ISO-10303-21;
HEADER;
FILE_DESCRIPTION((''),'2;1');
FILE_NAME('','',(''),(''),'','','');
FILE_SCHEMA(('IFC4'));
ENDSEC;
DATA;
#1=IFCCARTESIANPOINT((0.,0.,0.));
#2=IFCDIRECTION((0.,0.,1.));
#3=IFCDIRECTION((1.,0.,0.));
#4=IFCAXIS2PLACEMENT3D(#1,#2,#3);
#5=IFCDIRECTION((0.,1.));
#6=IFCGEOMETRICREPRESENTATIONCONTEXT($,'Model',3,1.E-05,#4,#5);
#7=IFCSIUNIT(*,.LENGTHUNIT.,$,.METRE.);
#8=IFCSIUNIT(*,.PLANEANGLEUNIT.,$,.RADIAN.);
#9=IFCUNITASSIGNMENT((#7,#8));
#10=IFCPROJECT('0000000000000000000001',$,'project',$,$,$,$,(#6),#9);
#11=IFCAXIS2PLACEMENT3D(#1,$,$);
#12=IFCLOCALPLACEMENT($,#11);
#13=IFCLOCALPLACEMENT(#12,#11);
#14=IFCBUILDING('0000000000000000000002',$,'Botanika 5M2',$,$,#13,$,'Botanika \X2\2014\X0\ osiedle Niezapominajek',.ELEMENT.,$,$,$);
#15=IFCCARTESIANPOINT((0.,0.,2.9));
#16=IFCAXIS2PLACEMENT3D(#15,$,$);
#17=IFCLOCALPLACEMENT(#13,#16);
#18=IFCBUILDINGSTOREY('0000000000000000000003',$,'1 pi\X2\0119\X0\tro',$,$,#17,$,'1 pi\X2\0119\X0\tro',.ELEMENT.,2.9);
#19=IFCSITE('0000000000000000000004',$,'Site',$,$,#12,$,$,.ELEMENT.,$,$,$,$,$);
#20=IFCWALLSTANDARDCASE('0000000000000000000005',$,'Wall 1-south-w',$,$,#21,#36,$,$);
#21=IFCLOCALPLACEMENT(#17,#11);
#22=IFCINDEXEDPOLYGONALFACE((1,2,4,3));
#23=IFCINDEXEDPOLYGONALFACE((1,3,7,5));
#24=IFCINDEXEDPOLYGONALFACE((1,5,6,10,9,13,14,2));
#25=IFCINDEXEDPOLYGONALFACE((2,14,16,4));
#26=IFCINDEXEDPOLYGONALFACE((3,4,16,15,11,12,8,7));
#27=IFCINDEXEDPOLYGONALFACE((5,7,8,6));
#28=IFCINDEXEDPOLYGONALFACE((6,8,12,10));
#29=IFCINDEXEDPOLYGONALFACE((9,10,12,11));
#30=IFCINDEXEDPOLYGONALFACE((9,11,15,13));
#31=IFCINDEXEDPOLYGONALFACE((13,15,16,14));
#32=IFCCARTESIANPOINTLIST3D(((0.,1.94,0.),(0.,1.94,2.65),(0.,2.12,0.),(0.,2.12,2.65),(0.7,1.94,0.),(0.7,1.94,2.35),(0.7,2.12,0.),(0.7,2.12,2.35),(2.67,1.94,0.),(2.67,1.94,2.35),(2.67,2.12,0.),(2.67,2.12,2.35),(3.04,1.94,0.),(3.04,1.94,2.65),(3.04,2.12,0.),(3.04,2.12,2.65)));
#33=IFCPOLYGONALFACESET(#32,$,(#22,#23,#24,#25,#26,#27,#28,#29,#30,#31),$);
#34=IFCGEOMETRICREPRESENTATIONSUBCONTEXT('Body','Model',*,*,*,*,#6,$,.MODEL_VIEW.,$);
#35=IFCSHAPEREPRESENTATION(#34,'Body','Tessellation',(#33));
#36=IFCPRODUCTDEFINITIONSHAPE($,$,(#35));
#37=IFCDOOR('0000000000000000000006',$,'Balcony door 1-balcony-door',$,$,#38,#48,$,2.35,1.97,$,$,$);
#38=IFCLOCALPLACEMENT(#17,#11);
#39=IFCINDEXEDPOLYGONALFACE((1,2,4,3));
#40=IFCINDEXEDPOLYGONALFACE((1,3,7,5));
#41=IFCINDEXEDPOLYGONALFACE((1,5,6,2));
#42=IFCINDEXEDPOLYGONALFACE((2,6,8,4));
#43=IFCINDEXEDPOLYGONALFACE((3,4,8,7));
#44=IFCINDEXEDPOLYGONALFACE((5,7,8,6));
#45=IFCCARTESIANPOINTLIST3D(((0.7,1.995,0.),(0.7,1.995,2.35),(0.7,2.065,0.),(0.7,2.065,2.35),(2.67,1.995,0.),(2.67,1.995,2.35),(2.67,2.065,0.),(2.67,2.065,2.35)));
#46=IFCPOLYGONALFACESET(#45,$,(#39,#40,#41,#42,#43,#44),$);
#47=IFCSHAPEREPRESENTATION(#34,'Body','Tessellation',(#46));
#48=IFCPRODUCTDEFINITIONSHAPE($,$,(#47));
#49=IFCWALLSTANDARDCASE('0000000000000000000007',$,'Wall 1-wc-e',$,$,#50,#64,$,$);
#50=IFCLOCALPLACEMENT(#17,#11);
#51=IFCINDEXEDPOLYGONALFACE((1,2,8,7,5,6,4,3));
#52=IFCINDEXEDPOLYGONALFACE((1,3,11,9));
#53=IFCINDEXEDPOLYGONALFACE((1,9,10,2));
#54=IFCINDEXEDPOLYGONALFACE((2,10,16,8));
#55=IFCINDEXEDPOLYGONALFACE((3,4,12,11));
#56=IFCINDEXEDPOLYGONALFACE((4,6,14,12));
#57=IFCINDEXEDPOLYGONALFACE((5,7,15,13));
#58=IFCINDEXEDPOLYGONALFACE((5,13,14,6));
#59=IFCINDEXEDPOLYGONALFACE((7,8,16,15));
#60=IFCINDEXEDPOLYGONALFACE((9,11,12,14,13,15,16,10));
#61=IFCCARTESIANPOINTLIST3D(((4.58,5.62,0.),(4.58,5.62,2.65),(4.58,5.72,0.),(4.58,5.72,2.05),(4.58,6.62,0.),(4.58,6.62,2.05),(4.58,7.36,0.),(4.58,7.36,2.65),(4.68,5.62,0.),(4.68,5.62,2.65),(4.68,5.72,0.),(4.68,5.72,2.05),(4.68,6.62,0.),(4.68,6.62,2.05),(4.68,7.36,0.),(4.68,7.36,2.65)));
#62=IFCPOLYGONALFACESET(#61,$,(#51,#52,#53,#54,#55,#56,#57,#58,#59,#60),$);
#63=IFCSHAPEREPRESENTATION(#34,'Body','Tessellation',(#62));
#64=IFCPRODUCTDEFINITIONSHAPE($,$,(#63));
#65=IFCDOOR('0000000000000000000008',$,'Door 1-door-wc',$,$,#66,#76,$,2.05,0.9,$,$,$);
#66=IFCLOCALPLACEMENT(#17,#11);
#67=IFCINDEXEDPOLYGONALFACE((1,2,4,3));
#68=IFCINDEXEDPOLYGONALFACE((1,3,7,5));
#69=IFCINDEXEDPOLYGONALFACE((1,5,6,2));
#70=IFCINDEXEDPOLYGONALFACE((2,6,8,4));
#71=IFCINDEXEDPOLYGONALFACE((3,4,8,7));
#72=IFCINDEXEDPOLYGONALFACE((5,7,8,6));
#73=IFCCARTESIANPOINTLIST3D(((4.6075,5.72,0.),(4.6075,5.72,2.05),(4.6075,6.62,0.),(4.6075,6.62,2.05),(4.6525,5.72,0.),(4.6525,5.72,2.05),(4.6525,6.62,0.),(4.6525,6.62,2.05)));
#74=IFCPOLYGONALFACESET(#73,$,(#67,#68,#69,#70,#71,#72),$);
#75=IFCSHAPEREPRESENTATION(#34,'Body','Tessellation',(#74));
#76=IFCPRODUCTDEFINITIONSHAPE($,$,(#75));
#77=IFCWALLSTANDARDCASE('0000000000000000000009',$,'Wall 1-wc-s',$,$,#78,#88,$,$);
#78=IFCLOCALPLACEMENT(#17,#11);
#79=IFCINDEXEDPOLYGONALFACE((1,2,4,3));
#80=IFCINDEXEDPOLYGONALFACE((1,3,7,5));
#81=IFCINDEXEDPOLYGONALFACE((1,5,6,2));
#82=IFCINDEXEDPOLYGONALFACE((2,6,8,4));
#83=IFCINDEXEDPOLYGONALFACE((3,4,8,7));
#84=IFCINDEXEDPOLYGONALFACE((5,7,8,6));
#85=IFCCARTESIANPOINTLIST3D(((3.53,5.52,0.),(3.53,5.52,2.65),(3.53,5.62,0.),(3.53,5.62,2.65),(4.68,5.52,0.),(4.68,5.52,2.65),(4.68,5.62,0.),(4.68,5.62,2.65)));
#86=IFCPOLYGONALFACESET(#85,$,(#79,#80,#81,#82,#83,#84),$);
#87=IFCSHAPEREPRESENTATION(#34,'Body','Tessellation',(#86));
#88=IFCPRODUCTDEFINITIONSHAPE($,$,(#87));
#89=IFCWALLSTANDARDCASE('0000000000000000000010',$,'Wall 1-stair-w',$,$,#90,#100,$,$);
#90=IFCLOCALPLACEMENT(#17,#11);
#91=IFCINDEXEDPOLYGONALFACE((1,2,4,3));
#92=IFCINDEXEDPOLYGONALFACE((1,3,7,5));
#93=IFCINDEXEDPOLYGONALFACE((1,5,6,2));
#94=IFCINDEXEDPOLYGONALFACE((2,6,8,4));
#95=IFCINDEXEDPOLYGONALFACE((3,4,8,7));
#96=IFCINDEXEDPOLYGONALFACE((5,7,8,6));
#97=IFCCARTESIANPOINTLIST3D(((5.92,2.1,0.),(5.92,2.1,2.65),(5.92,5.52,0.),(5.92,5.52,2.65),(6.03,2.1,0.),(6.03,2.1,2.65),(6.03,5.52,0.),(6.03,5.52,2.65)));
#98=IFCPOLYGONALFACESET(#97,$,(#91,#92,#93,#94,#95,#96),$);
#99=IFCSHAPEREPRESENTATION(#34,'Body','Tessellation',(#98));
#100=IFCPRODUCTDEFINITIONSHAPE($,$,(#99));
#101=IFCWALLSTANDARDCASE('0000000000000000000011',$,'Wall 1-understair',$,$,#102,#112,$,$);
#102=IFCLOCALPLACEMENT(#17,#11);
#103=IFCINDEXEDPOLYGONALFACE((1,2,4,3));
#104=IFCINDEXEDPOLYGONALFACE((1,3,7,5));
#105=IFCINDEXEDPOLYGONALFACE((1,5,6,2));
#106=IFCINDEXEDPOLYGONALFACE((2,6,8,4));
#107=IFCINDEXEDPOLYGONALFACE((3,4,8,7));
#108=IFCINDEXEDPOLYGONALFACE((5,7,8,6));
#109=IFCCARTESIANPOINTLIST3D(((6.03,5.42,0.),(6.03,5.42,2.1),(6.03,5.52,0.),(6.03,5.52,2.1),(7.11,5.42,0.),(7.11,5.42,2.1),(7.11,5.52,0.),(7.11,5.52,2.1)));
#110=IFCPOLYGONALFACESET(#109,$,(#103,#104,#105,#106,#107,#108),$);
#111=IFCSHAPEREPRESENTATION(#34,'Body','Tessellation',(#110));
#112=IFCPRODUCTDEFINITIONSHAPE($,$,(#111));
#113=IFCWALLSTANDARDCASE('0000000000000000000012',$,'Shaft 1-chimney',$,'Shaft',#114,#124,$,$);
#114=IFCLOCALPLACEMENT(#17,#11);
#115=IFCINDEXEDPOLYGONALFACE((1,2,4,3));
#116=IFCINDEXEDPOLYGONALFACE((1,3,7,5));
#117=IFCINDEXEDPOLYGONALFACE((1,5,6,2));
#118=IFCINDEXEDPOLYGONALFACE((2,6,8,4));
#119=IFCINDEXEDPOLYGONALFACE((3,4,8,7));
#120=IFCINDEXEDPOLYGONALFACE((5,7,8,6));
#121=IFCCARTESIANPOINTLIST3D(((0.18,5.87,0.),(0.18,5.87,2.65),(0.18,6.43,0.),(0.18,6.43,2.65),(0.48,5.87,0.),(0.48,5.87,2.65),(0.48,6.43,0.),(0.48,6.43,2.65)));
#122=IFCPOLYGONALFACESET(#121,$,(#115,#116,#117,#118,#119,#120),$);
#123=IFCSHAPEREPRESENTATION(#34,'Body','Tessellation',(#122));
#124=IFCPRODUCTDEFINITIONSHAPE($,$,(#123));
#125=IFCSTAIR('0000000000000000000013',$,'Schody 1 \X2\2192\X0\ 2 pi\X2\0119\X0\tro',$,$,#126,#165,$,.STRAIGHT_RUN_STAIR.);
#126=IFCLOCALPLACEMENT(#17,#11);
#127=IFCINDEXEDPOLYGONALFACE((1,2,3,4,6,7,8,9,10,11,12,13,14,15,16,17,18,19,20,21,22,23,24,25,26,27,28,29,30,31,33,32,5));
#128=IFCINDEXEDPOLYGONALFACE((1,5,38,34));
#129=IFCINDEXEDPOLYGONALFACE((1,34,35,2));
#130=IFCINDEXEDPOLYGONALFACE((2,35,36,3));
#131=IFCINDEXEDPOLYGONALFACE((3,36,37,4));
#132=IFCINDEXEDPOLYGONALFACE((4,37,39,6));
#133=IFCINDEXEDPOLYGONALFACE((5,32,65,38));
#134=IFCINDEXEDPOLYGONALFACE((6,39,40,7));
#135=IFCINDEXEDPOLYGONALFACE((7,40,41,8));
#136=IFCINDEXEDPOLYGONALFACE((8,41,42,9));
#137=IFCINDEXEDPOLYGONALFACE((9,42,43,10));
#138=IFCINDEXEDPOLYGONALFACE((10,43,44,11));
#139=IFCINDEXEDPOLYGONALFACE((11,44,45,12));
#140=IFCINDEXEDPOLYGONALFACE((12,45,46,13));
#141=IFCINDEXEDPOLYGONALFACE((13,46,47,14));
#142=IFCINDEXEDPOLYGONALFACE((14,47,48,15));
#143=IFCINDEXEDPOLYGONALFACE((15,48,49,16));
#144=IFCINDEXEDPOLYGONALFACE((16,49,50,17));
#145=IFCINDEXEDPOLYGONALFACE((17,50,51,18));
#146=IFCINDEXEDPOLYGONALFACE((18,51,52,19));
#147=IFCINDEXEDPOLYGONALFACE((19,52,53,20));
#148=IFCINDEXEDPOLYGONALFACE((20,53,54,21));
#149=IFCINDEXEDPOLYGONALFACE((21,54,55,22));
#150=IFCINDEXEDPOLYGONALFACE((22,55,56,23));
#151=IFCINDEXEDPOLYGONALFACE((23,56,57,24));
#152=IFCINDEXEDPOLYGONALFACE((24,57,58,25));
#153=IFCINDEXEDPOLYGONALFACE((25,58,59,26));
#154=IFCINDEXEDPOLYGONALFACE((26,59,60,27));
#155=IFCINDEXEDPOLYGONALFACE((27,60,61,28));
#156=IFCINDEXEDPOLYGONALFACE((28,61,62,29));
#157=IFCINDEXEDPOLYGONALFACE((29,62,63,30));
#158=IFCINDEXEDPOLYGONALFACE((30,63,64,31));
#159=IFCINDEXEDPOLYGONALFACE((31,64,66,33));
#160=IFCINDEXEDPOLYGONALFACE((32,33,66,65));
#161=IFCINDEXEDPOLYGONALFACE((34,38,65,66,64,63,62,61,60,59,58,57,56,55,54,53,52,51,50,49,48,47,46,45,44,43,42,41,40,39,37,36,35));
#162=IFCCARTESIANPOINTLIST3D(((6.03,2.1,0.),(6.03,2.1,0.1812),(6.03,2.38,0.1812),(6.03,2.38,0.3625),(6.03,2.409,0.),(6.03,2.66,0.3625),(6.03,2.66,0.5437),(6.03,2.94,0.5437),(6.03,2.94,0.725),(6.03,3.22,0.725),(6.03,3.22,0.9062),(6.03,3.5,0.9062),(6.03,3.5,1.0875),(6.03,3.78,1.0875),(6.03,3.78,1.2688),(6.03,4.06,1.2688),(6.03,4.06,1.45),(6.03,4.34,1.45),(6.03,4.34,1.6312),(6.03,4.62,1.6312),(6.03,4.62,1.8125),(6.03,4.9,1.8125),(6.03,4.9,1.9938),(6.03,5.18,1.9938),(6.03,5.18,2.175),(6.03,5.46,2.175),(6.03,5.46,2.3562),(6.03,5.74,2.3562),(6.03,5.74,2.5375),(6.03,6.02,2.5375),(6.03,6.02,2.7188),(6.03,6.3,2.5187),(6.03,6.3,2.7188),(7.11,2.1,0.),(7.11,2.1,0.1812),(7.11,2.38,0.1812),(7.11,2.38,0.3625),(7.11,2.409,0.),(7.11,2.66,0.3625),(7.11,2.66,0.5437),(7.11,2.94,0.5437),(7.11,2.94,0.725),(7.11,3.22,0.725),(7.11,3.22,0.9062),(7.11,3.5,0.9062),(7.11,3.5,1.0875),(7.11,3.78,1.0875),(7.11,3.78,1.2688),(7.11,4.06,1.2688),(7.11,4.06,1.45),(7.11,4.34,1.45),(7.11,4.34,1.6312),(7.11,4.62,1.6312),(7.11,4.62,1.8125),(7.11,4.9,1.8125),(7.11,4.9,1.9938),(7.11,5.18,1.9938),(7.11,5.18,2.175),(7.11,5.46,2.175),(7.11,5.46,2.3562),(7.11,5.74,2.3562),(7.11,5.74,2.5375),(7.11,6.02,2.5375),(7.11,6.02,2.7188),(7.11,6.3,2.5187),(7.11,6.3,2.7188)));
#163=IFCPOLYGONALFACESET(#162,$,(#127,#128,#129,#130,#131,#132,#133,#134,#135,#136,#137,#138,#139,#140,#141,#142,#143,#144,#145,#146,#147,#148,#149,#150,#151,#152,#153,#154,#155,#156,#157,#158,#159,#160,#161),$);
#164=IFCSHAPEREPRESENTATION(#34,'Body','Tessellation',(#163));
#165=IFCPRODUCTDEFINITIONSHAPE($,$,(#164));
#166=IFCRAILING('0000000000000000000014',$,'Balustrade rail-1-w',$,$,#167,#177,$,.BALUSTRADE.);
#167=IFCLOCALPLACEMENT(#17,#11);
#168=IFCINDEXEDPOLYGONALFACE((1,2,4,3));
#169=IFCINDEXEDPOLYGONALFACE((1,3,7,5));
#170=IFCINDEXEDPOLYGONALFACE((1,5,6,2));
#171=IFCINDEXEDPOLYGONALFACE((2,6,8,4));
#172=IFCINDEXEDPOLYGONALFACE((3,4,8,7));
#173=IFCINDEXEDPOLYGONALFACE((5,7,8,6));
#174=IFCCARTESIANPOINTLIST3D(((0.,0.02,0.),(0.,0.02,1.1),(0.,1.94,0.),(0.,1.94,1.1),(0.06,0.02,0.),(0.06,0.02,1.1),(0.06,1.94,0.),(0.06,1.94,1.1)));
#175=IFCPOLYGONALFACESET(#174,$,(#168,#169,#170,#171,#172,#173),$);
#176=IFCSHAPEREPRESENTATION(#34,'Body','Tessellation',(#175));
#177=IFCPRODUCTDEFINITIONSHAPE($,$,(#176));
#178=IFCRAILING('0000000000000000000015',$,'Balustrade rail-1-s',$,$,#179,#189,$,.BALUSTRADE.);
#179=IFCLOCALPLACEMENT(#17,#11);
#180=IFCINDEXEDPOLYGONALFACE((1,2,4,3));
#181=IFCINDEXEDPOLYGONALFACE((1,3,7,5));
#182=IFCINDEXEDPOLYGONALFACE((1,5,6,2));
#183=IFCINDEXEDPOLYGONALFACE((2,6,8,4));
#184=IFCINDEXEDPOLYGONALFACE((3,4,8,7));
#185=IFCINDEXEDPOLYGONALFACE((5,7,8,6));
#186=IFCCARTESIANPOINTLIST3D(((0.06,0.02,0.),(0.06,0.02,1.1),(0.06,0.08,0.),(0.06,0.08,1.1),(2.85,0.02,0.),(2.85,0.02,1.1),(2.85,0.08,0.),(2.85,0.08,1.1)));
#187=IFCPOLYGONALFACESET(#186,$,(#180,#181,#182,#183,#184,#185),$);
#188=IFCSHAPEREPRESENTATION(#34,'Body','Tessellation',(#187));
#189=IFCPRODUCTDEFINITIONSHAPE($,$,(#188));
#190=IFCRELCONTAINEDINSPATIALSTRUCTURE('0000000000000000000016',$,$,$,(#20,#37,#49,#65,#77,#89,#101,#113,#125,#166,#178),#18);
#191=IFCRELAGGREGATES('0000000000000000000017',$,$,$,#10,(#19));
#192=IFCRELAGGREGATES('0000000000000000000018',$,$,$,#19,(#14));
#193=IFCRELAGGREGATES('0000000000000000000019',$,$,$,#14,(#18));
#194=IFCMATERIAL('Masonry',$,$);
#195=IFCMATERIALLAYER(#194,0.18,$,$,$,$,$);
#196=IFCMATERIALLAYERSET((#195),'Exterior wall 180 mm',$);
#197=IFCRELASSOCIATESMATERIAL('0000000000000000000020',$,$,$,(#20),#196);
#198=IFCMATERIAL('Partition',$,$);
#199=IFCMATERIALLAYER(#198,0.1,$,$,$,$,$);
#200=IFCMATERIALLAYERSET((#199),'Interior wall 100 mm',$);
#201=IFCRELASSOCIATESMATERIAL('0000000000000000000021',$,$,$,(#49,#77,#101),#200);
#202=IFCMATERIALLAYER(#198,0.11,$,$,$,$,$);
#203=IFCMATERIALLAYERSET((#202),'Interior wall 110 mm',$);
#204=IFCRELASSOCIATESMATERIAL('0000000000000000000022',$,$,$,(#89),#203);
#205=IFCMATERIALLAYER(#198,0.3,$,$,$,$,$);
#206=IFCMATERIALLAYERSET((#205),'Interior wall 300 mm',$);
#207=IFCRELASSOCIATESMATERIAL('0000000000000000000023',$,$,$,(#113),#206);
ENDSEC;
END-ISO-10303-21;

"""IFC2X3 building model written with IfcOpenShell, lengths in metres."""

from ifc_helpers import new_model, si_unit, direction, frame, frame_2d, origin, origin_with_axes, place, context, subcontext, project, spatial, polyline, rectangle, outline, extrude, material, layer, layer_set, layer_usage, element, fill, save


model = new_model("IFC2X3")

# Units and contexts
model_context = context("Model", 3, precision=1e-05, world=origin_with_axes(), true_north=direction((0.0, 1.0)))
body_context = subcontext(model_context, "Body", "Model", "MODEL_VIEW")
ifc_project = project(units=[si_unit("LENGTHUNIT", "METRE"), si_unit("PLANEANGLEUNIT", "RADIAN")], contexts=[model_context])

# Site, building, storey
site_placement = place(None, origin())
site = spatial("IfcSite", under=ifc_project, at=site_placement, Name="Site", CompositionType="ELEMENT")
building_placement = place(site_placement, origin())
building = spatial("IfcBuilding", under=site, at=building_placement, Name="Botanika 5M2", LongName="Botanika — osiedle Niezapominajek", CompositionType="ELEMENT")
storey_placement = place(building_placement, frame((0.0, 0.0, 2.9)))
storey = spatial("IfcBuildingStorey", under=building, at=storey_placement, Name="1 piętro", LongName="1 piętro", CompositionType="ELEMENT", Elevation=2.9)

# Shared definitions
ifc_material_1 = material(Name="Masonry")
ifc_layer_1 = layer(ifc_material_1, 0.18)
ifc_layer_set_1 = layer_set([ifc_layer_1], Name="Exterior wall 180 mm")
ifc_layer_usage_1 = layer_usage(ifc_layer_set_1, "AXIS2", "POSITIVE", -0.09)

# Walls, openings, doors
wall_1_placement = place(storey_placement, frame((0.0, 2.03, 0.0)))
wall_1 = element("IfcWallStandardCase", 1, at=wall_1_placement, inside=storey, material=ifc_layer_usage_1, Name="Wall 1-south-w", context=body_context, shape_type="SweptSolid", body=[
    extrude(rectangle(XDim=3.04, YDim=0.18, at=frame_2d((1.52, 0.0))), origin_with_axes(), (0.0, 0.0, 1.0), 2.65),
])
opening_1_placement = place(wall_1_placement, frame((0.7, 0.14, 0.0), z_axis=(0.0, -1.0, 0.0), x_axis=(1.0, 0.0, 0.0)))
opening_1 = element("IfcOpeningElement", 2, at=opening_1_placement, cuts=wall_1, context=body_context, shape_type="SweptSolid", body=[
    extrude(rectangle(XDim=1.97, YDim=2.35, at=frame_2d((0.985, 1.175))), origin_with_axes(), (0.0, 0.0, 1.0), 0.28),
])
door_1_placement = place(wall_1_placement, frame((0.7, 0.0, 0.0)))
door_1 = element("IfcDoor", 3, at=door_1_placement, inside=storey, Name="Balcony door 1-balcony-door", OverallHeight=2.35, OverallWidth=1.97, context=body_context, shape_type="SweptSolid", body=[
    extrude(rectangle(XDim=1.97, YDim=0.07, at=frame_2d((0.985, 0.0))), origin_with_axes(), (0.0, 0.0, 1.0), 2.35),
])
fill(opening_1, door_1)
ifc_material_2 = material(Name="Partition")
ifc_layer_2 = layer(ifc_material_2, 0.1)
ifc_layer_set_2 = layer_set([ifc_layer_2], Name="Interior wall 100 mm")
ifc_layer_usage_2 = layer_usage(ifc_layer_set_2, "AXIS2", "POSITIVE", -0.05)
wall_2_placement = place(storey_placement, frame((4.63, 7.36, 0.0), z_axis=(0.0, 0.0, 1.0), x_axis=(0.0, -1.0, 0.0)))
wall_2 = element("IfcWallStandardCase", 4, at=wall_2_placement, inside=storey, material=ifc_layer_usage_2, Name="Wall 1-wc-e", context=body_context, shape_type="SweptSolid", body=[
    extrude(rectangle(XDim=1.74, YDim=0.1, at=frame_2d((0.87, 0.0))), origin_with_axes(), (0.0, 0.0, 1.0), 2.65),
])
opening_2_placement = place(wall_2_placement, frame((0.74, 0.1, 0.0), z_axis=(0.0, -1.0, 0.0), x_axis=(1.0, 0.0, 0.0)))
opening_2 = element("IfcOpeningElement", 5, at=opening_2_placement, cuts=wall_2, context=body_context, shape_type="SweptSolid", body=[
    extrude(rectangle(XDim=0.9, YDim=2.05, at=frame_2d((0.45, 1.025))), origin_with_axes(), (0.0, 0.0, 1.0), 0.2),
])
door_2_placement = place(wall_2_placement, frame((0.74, 0.0, 0.0)))
door_2 = element("IfcDoor", 6, at=door_2_placement, inside=storey, Name="Door 1-door-wc", OverallHeight=2.05, OverallWidth=0.9, context=body_context, shape_type="SweptSolid", body=[
    extrude(rectangle(XDim=0.9, YDim=0.045, at=frame_2d((0.45, 0.0))), origin_with_axes(), (0.0, 0.0, 1.0), 2.05),
])
fill(opening_2, door_2)

# Walls
wall_3_placement = place(storey_placement, frame((3.53, 5.57, 0.0)))
element("IfcWallStandardCase", 7, at=wall_3_placement, inside=storey, material=ifc_layer_usage_2, Name="Wall 1-wc-s", context=body_context, shape_type="SweptSolid", body=[
    extrude(rectangle(XDim=1.15, YDim=0.1, at=frame_2d((0.575, 0.0))), origin_with_axes(), (0.0, 0.0, 1.0), 2.65),
])
ifc_layer_3 = layer(ifc_material_2, 0.11)
ifc_layer_set_3 = layer_set([ifc_layer_3], Name="Interior wall 110 mm")
ifc_layer_usage_3 = layer_usage(ifc_layer_set_3, "AXIS2", "POSITIVE", -0.055)
wall_4_placement = place(storey_placement, frame((5.975, 5.52, 0.0), z_axis=(0.0, 0.0, 1.0), x_axis=(0.0, -1.0, 0.0)))
element("IfcWallStandardCase", 8, at=wall_4_placement, inside=storey, material=ifc_layer_usage_3, Name="Wall 1-stair-w", context=body_context, shape_type="SweptSolid", body=[
    extrude(rectangle(XDim=3.42, YDim=0.11, at=frame_2d((1.71, 0.0))), origin_with_axes(), (0.0, 0.0, 1.0), 2.65),
])
wall_5_placement = place(storey_placement, frame((6.03, 5.47, 0.0)))
element("IfcWallStandardCase", 9, at=wall_5_placement, inside=storey, material=ifc_layer_usage_2, Name="Wall 1-understair", context=body_context, shape_type="SweptSolid", body=[
    extrude(rectangle(XDim=1.08, YDim=0.1, at=frame_2d((0.54, 0.0))), origin_with_axes(), (0.0, 0.0, 1.0), 2.1),
])
ifc_layer_4 = layer(ifc_material_2, 0.3)
ifc_layer_set_4 = layer_set([ifc_layer_4], Name="Interior wall 300 mm")
ifc_layer_usage_4 = layer_usage(ifc_layer_set_4, "AXIS2", "POSITIVE", -0.15)
wall_6_placement = place(storey_placement, frame((0.33, 6.43, 0.0), z_axis=(0.0, 0.0, 1.0), x_axis=(0.0, -1.0, 0.0)))
element("IfcWallStandardCase", 10, at=wall_6_placement, inside=storey, material=ifc_layer_usage_4, Name="Shaft 1-chimney", ObjectType="Shaft", context=body_context, shape_type="SweptSolid", body=[
    extrude(rectangle(XDim=0.56, YDim=0.3, at=frame_2d((0.28, 0.0))), origin_with_axes(), (0.0, 0.0, 1.0), 2.65),
])

# Stair
stair_placement = place(storey_placement, frame((6.03, 2.1, 0.0), z_axis=(1.0, 0.0, 0.0), x_axis=(0.0, 1.0, 0.0)))
element("IfcStair", 11, at=stair_placement, inside=storey, Name="Schody 1 → 2 piętro", ShapeType="STRAIGHT_RUN_STAIR", context=body_context, shape_type="SweptSolid", body=[
    extrude(outline(polyline([(0.0, 0.0), (0.0, 0.1812), (0.28, 0.1812), (0.28, 0.3625), (0.56, 0.3625), (0.56, 0.5437), (0.84, 0.5437), (0.84, 0.725), (1.12, 0.725), (1.12, 0.9062), (1.4, 0.9062), (1.4, 1.0875), (1.68, 1.0875), (1.68, 1.2688), (1.96, 1.2688), (1.96, 1.45), (2.24, 1.45), (2.24, 1.6313), (2.52, 1.6313), (2.52, 1.8125), (2.8, 1.8125), (2.8, 1.9937), (3.08, 1.9937), (3.08, 2.175), (3.36, 2.175), (3.36, 2.3563), (3.64, 2.3563), (3.64, 2.5375), (3.92, 2.5375), (3.92, 2.7188), (4.2, 2.7188), (4.2, 2.9), (4.2, 2.5187), (0.309, 0.0), (0.0, 0.0)])), origin_with_axes(), (0.0, 0.0, 1.0), 1.08),
])

# Railings
railing_1_placement = place(storey_placement, frame((0.0, 0.02, 0.0)))
element("IfcRailing", 12, at=railing_1_placement, inside=storey, Name="Balustrade rail-1-w", PredefinedType="BALUSTRADE", context=body_context, shape_type="SweptSolid", body=[
    extrude(rectangle(XDim=0.06, YDim=1.92, at=frame_2d((0.03, 0.96))), origin_with_axes(), (0.0, 0.0, 1.0), 1.1),
])
railing_2_placement = place(storey_placement, frame((0.06, 0.02, 0.0)))
element("IfcRailing", 13, at=railing_2_placement, inside=storey, Name="Balustrade rail-1-s", PredefinedType="BALUSTRADE", context=body_context, shape_type="SweptSolid", body=[
    extrude(rectangle(XDim=2.79, YDim=0.06, at=frame_2d((1.395, 0.03))), origin_with_axes(), (0.0, 0.0, 1.0), 1.1),
])

save(model, "model.ifc")
